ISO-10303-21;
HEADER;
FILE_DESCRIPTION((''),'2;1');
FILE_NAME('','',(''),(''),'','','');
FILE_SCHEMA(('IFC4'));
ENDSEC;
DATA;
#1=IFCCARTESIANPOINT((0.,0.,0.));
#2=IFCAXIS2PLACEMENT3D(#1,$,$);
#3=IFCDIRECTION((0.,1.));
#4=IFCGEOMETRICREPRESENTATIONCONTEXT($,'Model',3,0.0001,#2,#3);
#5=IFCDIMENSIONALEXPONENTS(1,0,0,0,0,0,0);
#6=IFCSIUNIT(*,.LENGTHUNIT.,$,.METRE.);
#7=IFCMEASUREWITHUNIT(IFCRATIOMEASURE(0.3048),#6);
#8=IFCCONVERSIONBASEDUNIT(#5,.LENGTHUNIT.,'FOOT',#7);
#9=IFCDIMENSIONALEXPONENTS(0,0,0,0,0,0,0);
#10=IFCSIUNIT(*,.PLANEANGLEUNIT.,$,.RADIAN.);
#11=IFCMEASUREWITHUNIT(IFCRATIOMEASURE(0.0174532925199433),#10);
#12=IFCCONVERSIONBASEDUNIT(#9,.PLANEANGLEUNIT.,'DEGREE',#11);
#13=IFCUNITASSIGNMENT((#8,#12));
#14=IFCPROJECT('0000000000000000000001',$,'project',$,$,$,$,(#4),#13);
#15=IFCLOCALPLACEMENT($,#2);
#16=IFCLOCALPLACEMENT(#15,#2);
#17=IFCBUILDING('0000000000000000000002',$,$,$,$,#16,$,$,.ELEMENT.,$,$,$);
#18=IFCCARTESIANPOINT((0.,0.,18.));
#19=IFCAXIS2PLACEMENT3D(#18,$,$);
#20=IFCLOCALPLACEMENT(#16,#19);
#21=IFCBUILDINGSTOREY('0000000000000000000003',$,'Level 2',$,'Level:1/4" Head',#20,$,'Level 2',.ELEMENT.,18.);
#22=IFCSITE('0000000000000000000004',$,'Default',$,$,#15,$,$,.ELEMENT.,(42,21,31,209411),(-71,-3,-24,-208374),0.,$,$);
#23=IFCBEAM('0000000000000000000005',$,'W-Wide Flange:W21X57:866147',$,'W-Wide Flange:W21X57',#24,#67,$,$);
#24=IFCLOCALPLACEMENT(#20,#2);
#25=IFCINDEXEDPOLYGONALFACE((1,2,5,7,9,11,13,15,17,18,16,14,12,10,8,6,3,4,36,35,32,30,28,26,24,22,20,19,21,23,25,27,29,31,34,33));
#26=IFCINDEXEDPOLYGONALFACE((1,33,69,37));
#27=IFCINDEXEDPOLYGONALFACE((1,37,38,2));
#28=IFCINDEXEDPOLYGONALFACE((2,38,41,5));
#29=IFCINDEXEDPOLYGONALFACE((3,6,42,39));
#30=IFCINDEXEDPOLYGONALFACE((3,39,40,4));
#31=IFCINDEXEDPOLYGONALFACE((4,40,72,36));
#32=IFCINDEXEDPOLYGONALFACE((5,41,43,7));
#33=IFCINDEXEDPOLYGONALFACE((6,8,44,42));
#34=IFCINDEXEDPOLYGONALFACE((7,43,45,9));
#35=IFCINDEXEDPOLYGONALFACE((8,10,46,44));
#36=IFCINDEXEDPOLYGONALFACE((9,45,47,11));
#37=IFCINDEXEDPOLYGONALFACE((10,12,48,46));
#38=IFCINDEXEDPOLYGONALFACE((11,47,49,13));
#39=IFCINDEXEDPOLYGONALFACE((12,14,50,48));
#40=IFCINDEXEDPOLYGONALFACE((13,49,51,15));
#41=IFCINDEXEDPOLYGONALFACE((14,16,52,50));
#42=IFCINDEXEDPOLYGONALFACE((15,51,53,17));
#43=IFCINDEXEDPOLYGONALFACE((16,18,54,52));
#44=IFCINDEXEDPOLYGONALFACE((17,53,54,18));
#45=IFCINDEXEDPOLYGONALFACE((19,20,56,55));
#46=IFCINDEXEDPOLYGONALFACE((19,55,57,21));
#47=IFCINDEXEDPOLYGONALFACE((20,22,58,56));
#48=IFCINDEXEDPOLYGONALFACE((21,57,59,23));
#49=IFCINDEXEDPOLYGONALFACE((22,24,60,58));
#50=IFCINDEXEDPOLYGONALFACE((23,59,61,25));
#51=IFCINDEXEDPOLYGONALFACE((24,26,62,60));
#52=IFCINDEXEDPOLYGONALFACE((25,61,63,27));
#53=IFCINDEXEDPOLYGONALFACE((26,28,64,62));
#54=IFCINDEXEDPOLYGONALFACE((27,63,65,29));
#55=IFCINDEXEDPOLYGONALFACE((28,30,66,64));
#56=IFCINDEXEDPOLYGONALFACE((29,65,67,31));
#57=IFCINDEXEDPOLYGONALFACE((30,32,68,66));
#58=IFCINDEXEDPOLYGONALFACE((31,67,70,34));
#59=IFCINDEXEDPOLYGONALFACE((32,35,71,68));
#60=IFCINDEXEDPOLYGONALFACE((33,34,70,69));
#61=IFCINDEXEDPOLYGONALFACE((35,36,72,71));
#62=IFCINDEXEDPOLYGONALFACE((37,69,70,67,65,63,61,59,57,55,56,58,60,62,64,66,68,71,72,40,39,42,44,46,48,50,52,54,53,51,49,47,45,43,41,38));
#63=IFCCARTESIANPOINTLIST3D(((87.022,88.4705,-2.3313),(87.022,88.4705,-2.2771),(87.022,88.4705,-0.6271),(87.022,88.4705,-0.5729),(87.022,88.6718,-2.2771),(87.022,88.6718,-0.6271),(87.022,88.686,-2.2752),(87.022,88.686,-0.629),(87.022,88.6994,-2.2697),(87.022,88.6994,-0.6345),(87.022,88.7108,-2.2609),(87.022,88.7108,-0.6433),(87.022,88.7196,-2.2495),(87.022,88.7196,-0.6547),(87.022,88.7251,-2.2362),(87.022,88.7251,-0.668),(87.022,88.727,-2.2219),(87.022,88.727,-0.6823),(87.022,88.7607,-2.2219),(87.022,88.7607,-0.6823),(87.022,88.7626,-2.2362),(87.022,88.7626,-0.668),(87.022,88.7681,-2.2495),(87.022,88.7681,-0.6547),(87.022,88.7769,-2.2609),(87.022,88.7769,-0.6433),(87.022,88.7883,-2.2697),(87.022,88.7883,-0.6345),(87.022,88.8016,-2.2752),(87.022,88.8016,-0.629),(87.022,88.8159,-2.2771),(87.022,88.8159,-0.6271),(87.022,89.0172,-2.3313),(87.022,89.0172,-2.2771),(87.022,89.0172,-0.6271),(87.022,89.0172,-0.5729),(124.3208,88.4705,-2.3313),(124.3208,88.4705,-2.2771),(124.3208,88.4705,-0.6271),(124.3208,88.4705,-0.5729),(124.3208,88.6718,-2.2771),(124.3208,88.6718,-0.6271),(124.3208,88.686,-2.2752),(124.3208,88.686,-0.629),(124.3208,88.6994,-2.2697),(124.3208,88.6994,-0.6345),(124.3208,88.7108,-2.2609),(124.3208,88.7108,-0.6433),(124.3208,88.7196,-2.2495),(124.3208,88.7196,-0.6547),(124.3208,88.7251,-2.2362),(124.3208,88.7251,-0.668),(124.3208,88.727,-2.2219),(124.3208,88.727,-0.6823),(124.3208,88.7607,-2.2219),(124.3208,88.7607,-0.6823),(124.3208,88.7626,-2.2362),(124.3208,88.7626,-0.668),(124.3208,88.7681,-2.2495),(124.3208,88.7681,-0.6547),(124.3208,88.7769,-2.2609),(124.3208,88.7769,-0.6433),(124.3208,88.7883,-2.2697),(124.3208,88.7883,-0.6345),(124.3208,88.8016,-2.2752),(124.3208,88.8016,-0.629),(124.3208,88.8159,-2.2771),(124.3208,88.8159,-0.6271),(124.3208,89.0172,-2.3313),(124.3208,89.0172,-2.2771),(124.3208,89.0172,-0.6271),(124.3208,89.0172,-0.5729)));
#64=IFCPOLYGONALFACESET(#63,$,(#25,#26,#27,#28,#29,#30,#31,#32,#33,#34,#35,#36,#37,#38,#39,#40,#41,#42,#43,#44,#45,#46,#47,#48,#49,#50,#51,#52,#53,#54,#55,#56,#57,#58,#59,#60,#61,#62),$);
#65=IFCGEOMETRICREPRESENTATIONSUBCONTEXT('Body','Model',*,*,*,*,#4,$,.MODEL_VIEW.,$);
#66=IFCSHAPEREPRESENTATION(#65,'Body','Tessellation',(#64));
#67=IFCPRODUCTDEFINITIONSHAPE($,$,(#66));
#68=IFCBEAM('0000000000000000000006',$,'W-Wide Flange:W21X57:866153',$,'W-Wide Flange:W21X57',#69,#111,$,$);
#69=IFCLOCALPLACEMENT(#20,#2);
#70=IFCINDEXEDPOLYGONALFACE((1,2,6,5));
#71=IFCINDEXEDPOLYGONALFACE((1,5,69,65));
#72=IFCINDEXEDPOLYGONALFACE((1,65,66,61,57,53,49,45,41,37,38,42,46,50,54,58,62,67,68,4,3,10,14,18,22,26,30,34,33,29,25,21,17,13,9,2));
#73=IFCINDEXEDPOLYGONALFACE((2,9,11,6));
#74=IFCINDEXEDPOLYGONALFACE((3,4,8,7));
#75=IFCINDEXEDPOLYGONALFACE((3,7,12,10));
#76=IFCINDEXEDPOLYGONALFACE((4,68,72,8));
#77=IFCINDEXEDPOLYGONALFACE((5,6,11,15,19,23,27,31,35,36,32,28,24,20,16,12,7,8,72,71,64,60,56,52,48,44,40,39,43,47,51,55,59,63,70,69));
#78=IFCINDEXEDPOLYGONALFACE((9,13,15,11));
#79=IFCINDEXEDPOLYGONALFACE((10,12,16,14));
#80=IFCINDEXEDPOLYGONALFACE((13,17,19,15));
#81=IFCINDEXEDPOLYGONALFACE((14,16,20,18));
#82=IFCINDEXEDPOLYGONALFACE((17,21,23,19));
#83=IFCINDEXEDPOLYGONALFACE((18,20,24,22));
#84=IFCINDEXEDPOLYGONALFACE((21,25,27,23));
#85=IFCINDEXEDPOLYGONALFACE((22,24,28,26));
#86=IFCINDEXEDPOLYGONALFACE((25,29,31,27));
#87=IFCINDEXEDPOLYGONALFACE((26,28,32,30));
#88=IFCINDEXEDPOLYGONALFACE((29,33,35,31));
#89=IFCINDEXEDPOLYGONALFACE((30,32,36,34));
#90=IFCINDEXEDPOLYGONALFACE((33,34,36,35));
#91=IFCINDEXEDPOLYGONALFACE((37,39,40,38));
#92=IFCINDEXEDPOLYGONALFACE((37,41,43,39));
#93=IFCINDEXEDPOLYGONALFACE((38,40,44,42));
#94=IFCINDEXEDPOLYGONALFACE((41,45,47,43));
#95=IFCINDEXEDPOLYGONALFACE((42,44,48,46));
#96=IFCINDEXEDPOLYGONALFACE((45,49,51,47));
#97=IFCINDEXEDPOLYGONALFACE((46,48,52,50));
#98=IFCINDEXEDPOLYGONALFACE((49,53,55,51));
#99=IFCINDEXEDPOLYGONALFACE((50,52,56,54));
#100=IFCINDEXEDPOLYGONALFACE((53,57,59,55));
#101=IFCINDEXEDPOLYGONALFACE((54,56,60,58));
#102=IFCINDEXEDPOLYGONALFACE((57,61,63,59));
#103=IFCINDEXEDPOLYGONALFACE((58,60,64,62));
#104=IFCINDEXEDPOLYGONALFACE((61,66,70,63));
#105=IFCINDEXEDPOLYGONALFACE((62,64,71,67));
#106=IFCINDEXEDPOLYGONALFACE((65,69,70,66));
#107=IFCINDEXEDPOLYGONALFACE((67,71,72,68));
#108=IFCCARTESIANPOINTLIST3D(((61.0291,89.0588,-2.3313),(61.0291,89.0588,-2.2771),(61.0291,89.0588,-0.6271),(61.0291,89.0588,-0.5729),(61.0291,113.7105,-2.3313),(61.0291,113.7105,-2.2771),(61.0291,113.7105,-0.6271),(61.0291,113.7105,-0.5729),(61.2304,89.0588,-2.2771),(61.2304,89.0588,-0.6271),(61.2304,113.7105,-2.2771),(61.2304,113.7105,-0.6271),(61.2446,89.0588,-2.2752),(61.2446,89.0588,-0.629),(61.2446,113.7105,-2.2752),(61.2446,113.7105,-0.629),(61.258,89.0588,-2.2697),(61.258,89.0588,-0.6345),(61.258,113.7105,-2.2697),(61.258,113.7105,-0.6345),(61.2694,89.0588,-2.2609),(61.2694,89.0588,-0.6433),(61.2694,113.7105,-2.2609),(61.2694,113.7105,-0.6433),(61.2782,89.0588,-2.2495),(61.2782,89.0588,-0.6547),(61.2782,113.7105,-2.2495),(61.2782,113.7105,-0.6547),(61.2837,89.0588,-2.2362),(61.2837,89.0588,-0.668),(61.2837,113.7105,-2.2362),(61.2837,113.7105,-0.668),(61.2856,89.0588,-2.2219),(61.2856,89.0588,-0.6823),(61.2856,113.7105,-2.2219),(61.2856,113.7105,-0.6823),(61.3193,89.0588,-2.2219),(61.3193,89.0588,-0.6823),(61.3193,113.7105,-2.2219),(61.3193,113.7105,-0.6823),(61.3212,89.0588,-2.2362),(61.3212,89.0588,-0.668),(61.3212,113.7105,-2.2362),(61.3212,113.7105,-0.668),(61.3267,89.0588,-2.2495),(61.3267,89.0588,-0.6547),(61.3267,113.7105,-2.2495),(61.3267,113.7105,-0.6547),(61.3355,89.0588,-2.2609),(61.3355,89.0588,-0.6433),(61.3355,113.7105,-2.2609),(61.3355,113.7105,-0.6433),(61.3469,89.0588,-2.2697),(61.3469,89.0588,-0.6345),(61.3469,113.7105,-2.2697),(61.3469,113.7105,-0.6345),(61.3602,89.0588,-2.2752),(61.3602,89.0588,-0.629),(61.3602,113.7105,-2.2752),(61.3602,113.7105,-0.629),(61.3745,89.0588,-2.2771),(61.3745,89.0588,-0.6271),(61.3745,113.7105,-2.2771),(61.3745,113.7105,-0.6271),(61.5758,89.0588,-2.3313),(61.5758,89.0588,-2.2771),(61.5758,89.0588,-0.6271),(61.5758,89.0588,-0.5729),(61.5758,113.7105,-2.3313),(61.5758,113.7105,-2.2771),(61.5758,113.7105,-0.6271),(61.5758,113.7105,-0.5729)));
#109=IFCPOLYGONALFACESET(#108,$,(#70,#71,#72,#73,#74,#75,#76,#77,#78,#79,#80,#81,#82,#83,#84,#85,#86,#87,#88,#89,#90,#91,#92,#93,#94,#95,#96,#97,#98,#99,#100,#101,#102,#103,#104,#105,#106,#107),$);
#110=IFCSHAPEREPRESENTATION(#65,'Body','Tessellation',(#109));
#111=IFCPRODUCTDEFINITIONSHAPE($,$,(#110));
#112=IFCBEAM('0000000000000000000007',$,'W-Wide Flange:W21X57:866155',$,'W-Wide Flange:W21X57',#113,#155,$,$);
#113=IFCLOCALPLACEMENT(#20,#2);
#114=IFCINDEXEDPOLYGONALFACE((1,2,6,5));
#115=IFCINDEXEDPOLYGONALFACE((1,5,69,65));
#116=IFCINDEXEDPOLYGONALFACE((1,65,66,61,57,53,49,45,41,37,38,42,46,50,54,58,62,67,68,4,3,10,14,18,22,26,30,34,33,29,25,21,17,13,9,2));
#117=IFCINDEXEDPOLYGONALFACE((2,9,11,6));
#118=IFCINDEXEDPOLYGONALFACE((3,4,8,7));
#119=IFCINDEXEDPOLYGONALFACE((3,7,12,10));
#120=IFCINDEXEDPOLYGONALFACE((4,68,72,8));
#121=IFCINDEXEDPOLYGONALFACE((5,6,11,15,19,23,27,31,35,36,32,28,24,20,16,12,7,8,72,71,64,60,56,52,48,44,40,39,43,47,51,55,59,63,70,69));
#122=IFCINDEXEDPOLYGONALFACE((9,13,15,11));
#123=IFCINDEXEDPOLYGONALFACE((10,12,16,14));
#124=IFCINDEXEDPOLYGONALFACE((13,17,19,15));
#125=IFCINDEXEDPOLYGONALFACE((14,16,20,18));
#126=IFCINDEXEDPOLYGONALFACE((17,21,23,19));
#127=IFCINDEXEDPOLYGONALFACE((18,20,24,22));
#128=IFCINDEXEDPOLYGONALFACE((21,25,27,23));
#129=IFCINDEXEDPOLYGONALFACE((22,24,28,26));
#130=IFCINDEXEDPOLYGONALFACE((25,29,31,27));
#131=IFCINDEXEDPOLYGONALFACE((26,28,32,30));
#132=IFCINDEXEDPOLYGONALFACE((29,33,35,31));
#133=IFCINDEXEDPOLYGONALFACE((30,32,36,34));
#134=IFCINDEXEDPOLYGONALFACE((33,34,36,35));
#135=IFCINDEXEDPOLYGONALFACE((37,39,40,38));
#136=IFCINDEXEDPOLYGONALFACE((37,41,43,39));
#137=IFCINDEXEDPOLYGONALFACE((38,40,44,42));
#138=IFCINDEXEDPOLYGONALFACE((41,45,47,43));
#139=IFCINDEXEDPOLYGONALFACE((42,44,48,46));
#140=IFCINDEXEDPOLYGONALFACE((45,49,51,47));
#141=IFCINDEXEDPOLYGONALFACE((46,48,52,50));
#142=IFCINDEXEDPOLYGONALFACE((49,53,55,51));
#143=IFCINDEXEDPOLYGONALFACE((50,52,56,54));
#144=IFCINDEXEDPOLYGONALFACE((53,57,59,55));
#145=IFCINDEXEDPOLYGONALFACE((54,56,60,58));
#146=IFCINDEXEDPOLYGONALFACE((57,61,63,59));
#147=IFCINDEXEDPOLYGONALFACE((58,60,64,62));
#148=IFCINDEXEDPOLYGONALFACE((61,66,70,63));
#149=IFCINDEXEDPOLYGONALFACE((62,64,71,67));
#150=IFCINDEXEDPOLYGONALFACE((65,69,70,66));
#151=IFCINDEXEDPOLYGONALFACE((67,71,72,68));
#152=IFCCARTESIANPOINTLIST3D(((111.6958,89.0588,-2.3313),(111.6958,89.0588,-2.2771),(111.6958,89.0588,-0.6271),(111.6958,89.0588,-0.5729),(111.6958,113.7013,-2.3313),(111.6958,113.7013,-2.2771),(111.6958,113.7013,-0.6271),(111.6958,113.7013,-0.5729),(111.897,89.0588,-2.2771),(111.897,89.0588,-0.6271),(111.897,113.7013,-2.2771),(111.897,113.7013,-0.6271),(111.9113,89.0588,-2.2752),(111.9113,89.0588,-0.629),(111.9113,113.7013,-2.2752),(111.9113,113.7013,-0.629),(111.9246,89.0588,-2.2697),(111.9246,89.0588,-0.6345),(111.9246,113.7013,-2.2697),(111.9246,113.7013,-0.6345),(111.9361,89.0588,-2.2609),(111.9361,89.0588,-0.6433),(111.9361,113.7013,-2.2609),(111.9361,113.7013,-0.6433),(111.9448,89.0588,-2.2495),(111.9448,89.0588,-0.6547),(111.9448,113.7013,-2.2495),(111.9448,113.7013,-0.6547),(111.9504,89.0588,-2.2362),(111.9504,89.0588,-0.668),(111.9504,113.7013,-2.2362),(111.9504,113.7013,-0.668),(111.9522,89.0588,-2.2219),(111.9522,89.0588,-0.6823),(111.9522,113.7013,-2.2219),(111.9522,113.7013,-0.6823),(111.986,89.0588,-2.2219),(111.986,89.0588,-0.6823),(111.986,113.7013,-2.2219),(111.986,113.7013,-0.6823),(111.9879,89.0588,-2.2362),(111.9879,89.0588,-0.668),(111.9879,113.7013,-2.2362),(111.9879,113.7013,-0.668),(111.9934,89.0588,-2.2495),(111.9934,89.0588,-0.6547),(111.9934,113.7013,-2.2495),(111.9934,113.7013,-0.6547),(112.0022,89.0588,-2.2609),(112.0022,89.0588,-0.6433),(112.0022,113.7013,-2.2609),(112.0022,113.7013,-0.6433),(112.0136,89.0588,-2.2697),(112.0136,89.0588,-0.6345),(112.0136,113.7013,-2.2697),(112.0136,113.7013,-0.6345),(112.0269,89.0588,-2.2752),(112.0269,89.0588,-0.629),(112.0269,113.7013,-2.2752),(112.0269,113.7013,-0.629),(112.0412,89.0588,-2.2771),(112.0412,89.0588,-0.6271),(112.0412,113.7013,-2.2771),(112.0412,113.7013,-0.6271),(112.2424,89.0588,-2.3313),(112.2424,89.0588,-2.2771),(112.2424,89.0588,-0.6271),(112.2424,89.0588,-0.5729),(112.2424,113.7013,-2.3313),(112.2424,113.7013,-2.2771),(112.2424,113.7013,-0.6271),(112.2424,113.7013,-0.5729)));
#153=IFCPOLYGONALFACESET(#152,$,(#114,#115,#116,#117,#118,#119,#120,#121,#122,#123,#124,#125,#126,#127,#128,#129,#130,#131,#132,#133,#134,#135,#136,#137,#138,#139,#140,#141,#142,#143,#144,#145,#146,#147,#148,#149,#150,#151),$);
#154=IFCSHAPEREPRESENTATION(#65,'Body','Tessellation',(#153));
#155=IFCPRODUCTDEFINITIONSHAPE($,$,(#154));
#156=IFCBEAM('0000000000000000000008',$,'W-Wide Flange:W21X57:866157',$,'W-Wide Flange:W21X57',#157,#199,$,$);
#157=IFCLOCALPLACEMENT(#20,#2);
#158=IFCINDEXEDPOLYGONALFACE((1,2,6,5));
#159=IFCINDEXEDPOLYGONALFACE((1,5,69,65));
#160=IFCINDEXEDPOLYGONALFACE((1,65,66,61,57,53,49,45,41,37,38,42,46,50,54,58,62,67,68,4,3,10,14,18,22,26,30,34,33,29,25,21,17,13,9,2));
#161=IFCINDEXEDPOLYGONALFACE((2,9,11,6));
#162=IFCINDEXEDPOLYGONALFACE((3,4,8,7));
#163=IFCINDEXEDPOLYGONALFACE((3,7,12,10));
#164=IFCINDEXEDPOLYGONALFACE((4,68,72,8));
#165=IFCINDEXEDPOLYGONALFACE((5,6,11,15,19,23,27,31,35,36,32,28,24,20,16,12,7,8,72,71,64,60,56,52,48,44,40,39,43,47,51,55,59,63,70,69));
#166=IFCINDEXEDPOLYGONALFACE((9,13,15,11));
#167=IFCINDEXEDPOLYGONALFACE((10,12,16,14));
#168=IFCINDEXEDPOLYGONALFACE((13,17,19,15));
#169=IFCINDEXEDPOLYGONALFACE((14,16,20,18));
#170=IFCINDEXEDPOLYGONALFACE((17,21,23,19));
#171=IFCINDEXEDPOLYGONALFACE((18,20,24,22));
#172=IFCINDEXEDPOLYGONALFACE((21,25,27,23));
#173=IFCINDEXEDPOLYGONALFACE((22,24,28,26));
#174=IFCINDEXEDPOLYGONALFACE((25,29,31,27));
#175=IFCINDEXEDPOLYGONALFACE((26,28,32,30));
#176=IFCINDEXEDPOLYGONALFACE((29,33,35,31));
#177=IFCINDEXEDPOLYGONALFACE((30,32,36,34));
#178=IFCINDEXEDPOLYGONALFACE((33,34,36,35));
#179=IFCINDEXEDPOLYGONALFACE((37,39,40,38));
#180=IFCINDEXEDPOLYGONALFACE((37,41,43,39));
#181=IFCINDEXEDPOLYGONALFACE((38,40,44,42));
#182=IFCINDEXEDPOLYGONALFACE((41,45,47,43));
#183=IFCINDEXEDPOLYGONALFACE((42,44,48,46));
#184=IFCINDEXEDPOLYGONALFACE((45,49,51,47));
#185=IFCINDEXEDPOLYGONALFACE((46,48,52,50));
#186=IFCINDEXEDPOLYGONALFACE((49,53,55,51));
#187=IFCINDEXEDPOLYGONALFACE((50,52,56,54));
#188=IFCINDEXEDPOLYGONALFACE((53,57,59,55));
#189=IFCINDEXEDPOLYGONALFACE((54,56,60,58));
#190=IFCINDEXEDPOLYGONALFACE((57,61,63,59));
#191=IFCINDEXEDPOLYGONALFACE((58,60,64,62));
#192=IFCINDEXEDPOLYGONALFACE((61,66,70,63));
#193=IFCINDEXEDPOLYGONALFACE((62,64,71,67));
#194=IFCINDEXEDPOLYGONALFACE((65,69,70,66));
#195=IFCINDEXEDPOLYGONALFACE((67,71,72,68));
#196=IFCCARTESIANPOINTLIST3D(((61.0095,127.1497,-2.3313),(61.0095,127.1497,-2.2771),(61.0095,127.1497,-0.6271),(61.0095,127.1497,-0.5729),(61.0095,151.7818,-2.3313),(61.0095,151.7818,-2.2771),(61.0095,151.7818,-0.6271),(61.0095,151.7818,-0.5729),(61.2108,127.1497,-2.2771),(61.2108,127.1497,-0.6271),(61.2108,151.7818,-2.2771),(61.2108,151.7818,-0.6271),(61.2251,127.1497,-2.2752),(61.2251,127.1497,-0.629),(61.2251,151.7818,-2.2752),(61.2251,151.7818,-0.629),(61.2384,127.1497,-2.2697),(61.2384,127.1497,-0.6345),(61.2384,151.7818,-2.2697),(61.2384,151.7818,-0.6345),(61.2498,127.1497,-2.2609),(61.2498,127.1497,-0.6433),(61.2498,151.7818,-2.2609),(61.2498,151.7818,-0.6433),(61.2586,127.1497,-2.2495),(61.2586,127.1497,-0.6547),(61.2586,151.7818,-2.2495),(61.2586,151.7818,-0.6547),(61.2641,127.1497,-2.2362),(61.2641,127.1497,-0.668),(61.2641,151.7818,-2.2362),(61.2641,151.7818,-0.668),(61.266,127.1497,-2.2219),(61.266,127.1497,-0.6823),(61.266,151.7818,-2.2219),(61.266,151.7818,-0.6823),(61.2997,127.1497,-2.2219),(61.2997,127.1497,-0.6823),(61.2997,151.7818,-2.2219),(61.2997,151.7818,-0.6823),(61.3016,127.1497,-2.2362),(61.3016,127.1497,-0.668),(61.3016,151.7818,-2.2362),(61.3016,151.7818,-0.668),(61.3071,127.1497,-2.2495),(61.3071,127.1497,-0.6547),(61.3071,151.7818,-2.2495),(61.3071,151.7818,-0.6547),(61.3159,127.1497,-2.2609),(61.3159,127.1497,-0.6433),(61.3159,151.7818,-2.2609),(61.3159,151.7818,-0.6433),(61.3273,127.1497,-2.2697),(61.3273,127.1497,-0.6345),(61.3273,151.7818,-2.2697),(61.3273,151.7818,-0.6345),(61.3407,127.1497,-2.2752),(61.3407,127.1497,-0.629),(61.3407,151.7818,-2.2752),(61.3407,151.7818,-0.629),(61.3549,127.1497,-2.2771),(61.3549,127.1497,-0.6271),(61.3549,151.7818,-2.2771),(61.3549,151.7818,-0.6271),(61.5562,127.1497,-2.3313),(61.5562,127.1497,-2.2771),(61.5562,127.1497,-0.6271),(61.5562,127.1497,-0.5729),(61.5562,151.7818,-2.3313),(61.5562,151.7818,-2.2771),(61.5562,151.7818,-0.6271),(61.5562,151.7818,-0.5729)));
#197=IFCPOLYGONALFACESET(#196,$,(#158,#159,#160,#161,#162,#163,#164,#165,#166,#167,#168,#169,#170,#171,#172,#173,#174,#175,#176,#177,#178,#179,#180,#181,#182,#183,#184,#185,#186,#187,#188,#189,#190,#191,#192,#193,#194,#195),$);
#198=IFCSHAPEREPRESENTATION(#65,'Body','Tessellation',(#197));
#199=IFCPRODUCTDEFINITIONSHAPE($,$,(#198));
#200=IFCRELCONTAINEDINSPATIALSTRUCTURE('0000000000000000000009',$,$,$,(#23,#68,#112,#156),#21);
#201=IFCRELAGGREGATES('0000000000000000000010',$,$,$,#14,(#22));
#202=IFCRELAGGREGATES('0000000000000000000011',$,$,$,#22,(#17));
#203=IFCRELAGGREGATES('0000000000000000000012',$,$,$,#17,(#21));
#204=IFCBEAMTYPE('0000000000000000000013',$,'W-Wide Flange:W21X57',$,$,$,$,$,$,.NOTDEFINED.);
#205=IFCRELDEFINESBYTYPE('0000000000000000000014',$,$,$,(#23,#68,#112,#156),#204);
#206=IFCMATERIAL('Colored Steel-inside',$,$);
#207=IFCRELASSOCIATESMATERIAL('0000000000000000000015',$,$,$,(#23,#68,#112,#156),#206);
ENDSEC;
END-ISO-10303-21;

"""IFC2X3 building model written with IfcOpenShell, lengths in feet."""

from ifc_helpers import new_model, entity, si_unit, converted_unit, direction, frame, frame_2d, origin, place, context, subcontext, project, spatial, i_section, extrude, material, type_object, element, save


model = new_model("IFC2X3")

# Units and contexts
model_context = context("Model", 3, precision=0.0001, world=origin(), true_north=direction((0.0, 1.0)))
body_context = subcontext(model_context, "Body", "Model", "MODEL_VIEW")
ifc_project = project(units=[converted_unit("LENGTHUNIT", "FOOT", entity("IfcRatioMeasure", 0.3048), si_unit("LENGTHUNIT", "METRE"), dimensions=[1, 0, 0, 0, 0, 0, 0]), converted_unit("PLANEANGLEUNIT", "DEGREE", entity("IfcRatioMeasure", 0.0174532925199433), si_unit("PLANEANGLEUNIT", "RADIAN"), dimensions=[0, 0, 0, 0, 0, 0, 0])], contexts=[model_context])

# Site, building, storey
site_placement = place(None, origin())
site = spatial("IfcSite", under=ifc_project, at=site_placement, Name="Default", CompositionType="ELEMENT", RefLatitude=(42, 21, 31, 209411), RefLongitude=(-71, -3, -24, -208374), RefElevation=0.0)
building_placement = place(site_placement, origin())
building = spatial("IfcBuilding", under=site, at=building_placement, CompositionType="ELEMENT")
storey_placement = place(building_placement, frame((0.0, 0.0, 18.0)))
storey = spatial("IfcBuildingStorey", under=building, at=storey_placement, Name="Level 2", ObjectType="Level:1/4\" Head", LongName="Level 2", CompositionType="ELEMENT", Elevation=18.0)

# Shared definitions
ifc_material_1 = material(Name="Colored Steel-inside")

# Beams
beam_type_1 = type_object("IfcBeamType", Name="W-Wide Flange:W21X57", PredefinedType="NOTDEFINED")
beam_1_placement = place(storey_placement, frame((124.6358, 88.7438, 0.0), z_axis=(0.0, 0.0, 1.0), x_axis=(-1.0, 0.0, 0.0)))
element("IfcBeam", 1, at=beam_1_placement, inside=storey, type_object=beam_type_1, material=ifc_material_1, Name="W-Wide Flange:W21X57:866147", ObjectType="W-Wide Flange:W21X57", context=body_context, shape_type="SweptSolid", body=[
    extrude(i_section(OverallWidth=0.5467, OverallDepth=1.7583, WebThickness=0.0337, FlangeThickness=0.0542, FilletRadius=0.0552, at=frame_2d((0.0, 0.0), x_axis=(0.0, 1.0))), frame((0.315, 0.0, -1.4521), z_axis=(1.0, 0.0, 0.0), x_axis=(0.0, 0.0, -1.0)), (0.0, 0.0, 1.0), 37.2987),
])
beam_2_placement = place(storey_placement, frame((61.3024, 114.0968, 0.0), z_axis=(0.0, 0.0, 1.0), x_axis=(0.0, -1.0, 0.0)))
element("IfcBeam", 2, at=beam_2_placement, inside=storey, type_object=beam_type_1, material=ifc_material_1, Name="W-Wide Flange:W21X57:866153", ObjectType="W-Wide Flange:W21X57", context=body_context, shape_type="SweptSolid", body=[
    extrude(i_section(OverallWidth=0.5467, OverallDepth=1.7583, WebThickness=0.0338, FlangeThickness=0.0542, FilletRadius=0.0552, at=frame_2d((0.0, 0.0), x_axis=(0.0, 1.0))), frame((0.3863, 0.0, -1.4521), z_axis=(1.0, 0.0, 0.0), x_axis=(0.0, 0.0, -1.0)), (0.0, 0.0, 1.0), 24.6517),
])
beam_3_placement = place(storey_placement, frame((111.9691, 88.7438, 0.0), z_axis=(0.0, 0.0, 1.0), x_axis=(0.0, 1.0, 0.0)))
element("IfcBeam", 3, at=beam_3_placement, inside=storey, type_object=beam_type_1, material=ifc_material_1, Name="W-Wide Flange:W21X57:866155", ObjectType="W-Wide Flange:W21X57", context=body_context, shape_type="SweptSolid", body=[
    extrude(i_section(OverallWidth=0.5467, OverallDepth=1.7583, WebThickness=0.0337, FlangeThickness=0.0542, FilletRadius=0.0552, at=frame_2d((0.0, 0.0), x_axis=(0.0, 1.0))), frame((0.315, 0.0, -1.4521), z_axis=(1.0, 0.0, 0.0), x_axis=(0.0, 0.0, -1.0)), (0.0, 0.0, 1.0), 24.6425),
])
beam_4_placement = place(storey_placement, frame((61.2829, 152.0968, 0.0), z_axis=(0.0, 0.0, 1.0), x_axis=(0.0, -1.0, 0.0)))
element("IfcBeam", 4, at=beam_4_placement, inside=storey, type_object=beam_type_1, material=ifc_material_1, Name="W-Wide Flange:W21X57:866157", ObjectType="W-Wide Flange:W21X57", context=body_context, shape_type="SweptSolid", body=[
    extrude(i_section(OverallWidth=0.5467, OverallDepth=1.7583, WebThickness=0.0338, FlangeThickness=0.0542, FilletRadius=0.0552, at=frame_2d((0.0, 0.0), x_axis=(0.0, 1.0))), frame((0.315, 0.0, -1.4521), z_axis=(1.0, 0.0, 0.0), x_axis=(0.0, 0.0, -1.0)), (0.0, 0.0, 1.0), 24.6321),
])

save(model, "model.ifc")
